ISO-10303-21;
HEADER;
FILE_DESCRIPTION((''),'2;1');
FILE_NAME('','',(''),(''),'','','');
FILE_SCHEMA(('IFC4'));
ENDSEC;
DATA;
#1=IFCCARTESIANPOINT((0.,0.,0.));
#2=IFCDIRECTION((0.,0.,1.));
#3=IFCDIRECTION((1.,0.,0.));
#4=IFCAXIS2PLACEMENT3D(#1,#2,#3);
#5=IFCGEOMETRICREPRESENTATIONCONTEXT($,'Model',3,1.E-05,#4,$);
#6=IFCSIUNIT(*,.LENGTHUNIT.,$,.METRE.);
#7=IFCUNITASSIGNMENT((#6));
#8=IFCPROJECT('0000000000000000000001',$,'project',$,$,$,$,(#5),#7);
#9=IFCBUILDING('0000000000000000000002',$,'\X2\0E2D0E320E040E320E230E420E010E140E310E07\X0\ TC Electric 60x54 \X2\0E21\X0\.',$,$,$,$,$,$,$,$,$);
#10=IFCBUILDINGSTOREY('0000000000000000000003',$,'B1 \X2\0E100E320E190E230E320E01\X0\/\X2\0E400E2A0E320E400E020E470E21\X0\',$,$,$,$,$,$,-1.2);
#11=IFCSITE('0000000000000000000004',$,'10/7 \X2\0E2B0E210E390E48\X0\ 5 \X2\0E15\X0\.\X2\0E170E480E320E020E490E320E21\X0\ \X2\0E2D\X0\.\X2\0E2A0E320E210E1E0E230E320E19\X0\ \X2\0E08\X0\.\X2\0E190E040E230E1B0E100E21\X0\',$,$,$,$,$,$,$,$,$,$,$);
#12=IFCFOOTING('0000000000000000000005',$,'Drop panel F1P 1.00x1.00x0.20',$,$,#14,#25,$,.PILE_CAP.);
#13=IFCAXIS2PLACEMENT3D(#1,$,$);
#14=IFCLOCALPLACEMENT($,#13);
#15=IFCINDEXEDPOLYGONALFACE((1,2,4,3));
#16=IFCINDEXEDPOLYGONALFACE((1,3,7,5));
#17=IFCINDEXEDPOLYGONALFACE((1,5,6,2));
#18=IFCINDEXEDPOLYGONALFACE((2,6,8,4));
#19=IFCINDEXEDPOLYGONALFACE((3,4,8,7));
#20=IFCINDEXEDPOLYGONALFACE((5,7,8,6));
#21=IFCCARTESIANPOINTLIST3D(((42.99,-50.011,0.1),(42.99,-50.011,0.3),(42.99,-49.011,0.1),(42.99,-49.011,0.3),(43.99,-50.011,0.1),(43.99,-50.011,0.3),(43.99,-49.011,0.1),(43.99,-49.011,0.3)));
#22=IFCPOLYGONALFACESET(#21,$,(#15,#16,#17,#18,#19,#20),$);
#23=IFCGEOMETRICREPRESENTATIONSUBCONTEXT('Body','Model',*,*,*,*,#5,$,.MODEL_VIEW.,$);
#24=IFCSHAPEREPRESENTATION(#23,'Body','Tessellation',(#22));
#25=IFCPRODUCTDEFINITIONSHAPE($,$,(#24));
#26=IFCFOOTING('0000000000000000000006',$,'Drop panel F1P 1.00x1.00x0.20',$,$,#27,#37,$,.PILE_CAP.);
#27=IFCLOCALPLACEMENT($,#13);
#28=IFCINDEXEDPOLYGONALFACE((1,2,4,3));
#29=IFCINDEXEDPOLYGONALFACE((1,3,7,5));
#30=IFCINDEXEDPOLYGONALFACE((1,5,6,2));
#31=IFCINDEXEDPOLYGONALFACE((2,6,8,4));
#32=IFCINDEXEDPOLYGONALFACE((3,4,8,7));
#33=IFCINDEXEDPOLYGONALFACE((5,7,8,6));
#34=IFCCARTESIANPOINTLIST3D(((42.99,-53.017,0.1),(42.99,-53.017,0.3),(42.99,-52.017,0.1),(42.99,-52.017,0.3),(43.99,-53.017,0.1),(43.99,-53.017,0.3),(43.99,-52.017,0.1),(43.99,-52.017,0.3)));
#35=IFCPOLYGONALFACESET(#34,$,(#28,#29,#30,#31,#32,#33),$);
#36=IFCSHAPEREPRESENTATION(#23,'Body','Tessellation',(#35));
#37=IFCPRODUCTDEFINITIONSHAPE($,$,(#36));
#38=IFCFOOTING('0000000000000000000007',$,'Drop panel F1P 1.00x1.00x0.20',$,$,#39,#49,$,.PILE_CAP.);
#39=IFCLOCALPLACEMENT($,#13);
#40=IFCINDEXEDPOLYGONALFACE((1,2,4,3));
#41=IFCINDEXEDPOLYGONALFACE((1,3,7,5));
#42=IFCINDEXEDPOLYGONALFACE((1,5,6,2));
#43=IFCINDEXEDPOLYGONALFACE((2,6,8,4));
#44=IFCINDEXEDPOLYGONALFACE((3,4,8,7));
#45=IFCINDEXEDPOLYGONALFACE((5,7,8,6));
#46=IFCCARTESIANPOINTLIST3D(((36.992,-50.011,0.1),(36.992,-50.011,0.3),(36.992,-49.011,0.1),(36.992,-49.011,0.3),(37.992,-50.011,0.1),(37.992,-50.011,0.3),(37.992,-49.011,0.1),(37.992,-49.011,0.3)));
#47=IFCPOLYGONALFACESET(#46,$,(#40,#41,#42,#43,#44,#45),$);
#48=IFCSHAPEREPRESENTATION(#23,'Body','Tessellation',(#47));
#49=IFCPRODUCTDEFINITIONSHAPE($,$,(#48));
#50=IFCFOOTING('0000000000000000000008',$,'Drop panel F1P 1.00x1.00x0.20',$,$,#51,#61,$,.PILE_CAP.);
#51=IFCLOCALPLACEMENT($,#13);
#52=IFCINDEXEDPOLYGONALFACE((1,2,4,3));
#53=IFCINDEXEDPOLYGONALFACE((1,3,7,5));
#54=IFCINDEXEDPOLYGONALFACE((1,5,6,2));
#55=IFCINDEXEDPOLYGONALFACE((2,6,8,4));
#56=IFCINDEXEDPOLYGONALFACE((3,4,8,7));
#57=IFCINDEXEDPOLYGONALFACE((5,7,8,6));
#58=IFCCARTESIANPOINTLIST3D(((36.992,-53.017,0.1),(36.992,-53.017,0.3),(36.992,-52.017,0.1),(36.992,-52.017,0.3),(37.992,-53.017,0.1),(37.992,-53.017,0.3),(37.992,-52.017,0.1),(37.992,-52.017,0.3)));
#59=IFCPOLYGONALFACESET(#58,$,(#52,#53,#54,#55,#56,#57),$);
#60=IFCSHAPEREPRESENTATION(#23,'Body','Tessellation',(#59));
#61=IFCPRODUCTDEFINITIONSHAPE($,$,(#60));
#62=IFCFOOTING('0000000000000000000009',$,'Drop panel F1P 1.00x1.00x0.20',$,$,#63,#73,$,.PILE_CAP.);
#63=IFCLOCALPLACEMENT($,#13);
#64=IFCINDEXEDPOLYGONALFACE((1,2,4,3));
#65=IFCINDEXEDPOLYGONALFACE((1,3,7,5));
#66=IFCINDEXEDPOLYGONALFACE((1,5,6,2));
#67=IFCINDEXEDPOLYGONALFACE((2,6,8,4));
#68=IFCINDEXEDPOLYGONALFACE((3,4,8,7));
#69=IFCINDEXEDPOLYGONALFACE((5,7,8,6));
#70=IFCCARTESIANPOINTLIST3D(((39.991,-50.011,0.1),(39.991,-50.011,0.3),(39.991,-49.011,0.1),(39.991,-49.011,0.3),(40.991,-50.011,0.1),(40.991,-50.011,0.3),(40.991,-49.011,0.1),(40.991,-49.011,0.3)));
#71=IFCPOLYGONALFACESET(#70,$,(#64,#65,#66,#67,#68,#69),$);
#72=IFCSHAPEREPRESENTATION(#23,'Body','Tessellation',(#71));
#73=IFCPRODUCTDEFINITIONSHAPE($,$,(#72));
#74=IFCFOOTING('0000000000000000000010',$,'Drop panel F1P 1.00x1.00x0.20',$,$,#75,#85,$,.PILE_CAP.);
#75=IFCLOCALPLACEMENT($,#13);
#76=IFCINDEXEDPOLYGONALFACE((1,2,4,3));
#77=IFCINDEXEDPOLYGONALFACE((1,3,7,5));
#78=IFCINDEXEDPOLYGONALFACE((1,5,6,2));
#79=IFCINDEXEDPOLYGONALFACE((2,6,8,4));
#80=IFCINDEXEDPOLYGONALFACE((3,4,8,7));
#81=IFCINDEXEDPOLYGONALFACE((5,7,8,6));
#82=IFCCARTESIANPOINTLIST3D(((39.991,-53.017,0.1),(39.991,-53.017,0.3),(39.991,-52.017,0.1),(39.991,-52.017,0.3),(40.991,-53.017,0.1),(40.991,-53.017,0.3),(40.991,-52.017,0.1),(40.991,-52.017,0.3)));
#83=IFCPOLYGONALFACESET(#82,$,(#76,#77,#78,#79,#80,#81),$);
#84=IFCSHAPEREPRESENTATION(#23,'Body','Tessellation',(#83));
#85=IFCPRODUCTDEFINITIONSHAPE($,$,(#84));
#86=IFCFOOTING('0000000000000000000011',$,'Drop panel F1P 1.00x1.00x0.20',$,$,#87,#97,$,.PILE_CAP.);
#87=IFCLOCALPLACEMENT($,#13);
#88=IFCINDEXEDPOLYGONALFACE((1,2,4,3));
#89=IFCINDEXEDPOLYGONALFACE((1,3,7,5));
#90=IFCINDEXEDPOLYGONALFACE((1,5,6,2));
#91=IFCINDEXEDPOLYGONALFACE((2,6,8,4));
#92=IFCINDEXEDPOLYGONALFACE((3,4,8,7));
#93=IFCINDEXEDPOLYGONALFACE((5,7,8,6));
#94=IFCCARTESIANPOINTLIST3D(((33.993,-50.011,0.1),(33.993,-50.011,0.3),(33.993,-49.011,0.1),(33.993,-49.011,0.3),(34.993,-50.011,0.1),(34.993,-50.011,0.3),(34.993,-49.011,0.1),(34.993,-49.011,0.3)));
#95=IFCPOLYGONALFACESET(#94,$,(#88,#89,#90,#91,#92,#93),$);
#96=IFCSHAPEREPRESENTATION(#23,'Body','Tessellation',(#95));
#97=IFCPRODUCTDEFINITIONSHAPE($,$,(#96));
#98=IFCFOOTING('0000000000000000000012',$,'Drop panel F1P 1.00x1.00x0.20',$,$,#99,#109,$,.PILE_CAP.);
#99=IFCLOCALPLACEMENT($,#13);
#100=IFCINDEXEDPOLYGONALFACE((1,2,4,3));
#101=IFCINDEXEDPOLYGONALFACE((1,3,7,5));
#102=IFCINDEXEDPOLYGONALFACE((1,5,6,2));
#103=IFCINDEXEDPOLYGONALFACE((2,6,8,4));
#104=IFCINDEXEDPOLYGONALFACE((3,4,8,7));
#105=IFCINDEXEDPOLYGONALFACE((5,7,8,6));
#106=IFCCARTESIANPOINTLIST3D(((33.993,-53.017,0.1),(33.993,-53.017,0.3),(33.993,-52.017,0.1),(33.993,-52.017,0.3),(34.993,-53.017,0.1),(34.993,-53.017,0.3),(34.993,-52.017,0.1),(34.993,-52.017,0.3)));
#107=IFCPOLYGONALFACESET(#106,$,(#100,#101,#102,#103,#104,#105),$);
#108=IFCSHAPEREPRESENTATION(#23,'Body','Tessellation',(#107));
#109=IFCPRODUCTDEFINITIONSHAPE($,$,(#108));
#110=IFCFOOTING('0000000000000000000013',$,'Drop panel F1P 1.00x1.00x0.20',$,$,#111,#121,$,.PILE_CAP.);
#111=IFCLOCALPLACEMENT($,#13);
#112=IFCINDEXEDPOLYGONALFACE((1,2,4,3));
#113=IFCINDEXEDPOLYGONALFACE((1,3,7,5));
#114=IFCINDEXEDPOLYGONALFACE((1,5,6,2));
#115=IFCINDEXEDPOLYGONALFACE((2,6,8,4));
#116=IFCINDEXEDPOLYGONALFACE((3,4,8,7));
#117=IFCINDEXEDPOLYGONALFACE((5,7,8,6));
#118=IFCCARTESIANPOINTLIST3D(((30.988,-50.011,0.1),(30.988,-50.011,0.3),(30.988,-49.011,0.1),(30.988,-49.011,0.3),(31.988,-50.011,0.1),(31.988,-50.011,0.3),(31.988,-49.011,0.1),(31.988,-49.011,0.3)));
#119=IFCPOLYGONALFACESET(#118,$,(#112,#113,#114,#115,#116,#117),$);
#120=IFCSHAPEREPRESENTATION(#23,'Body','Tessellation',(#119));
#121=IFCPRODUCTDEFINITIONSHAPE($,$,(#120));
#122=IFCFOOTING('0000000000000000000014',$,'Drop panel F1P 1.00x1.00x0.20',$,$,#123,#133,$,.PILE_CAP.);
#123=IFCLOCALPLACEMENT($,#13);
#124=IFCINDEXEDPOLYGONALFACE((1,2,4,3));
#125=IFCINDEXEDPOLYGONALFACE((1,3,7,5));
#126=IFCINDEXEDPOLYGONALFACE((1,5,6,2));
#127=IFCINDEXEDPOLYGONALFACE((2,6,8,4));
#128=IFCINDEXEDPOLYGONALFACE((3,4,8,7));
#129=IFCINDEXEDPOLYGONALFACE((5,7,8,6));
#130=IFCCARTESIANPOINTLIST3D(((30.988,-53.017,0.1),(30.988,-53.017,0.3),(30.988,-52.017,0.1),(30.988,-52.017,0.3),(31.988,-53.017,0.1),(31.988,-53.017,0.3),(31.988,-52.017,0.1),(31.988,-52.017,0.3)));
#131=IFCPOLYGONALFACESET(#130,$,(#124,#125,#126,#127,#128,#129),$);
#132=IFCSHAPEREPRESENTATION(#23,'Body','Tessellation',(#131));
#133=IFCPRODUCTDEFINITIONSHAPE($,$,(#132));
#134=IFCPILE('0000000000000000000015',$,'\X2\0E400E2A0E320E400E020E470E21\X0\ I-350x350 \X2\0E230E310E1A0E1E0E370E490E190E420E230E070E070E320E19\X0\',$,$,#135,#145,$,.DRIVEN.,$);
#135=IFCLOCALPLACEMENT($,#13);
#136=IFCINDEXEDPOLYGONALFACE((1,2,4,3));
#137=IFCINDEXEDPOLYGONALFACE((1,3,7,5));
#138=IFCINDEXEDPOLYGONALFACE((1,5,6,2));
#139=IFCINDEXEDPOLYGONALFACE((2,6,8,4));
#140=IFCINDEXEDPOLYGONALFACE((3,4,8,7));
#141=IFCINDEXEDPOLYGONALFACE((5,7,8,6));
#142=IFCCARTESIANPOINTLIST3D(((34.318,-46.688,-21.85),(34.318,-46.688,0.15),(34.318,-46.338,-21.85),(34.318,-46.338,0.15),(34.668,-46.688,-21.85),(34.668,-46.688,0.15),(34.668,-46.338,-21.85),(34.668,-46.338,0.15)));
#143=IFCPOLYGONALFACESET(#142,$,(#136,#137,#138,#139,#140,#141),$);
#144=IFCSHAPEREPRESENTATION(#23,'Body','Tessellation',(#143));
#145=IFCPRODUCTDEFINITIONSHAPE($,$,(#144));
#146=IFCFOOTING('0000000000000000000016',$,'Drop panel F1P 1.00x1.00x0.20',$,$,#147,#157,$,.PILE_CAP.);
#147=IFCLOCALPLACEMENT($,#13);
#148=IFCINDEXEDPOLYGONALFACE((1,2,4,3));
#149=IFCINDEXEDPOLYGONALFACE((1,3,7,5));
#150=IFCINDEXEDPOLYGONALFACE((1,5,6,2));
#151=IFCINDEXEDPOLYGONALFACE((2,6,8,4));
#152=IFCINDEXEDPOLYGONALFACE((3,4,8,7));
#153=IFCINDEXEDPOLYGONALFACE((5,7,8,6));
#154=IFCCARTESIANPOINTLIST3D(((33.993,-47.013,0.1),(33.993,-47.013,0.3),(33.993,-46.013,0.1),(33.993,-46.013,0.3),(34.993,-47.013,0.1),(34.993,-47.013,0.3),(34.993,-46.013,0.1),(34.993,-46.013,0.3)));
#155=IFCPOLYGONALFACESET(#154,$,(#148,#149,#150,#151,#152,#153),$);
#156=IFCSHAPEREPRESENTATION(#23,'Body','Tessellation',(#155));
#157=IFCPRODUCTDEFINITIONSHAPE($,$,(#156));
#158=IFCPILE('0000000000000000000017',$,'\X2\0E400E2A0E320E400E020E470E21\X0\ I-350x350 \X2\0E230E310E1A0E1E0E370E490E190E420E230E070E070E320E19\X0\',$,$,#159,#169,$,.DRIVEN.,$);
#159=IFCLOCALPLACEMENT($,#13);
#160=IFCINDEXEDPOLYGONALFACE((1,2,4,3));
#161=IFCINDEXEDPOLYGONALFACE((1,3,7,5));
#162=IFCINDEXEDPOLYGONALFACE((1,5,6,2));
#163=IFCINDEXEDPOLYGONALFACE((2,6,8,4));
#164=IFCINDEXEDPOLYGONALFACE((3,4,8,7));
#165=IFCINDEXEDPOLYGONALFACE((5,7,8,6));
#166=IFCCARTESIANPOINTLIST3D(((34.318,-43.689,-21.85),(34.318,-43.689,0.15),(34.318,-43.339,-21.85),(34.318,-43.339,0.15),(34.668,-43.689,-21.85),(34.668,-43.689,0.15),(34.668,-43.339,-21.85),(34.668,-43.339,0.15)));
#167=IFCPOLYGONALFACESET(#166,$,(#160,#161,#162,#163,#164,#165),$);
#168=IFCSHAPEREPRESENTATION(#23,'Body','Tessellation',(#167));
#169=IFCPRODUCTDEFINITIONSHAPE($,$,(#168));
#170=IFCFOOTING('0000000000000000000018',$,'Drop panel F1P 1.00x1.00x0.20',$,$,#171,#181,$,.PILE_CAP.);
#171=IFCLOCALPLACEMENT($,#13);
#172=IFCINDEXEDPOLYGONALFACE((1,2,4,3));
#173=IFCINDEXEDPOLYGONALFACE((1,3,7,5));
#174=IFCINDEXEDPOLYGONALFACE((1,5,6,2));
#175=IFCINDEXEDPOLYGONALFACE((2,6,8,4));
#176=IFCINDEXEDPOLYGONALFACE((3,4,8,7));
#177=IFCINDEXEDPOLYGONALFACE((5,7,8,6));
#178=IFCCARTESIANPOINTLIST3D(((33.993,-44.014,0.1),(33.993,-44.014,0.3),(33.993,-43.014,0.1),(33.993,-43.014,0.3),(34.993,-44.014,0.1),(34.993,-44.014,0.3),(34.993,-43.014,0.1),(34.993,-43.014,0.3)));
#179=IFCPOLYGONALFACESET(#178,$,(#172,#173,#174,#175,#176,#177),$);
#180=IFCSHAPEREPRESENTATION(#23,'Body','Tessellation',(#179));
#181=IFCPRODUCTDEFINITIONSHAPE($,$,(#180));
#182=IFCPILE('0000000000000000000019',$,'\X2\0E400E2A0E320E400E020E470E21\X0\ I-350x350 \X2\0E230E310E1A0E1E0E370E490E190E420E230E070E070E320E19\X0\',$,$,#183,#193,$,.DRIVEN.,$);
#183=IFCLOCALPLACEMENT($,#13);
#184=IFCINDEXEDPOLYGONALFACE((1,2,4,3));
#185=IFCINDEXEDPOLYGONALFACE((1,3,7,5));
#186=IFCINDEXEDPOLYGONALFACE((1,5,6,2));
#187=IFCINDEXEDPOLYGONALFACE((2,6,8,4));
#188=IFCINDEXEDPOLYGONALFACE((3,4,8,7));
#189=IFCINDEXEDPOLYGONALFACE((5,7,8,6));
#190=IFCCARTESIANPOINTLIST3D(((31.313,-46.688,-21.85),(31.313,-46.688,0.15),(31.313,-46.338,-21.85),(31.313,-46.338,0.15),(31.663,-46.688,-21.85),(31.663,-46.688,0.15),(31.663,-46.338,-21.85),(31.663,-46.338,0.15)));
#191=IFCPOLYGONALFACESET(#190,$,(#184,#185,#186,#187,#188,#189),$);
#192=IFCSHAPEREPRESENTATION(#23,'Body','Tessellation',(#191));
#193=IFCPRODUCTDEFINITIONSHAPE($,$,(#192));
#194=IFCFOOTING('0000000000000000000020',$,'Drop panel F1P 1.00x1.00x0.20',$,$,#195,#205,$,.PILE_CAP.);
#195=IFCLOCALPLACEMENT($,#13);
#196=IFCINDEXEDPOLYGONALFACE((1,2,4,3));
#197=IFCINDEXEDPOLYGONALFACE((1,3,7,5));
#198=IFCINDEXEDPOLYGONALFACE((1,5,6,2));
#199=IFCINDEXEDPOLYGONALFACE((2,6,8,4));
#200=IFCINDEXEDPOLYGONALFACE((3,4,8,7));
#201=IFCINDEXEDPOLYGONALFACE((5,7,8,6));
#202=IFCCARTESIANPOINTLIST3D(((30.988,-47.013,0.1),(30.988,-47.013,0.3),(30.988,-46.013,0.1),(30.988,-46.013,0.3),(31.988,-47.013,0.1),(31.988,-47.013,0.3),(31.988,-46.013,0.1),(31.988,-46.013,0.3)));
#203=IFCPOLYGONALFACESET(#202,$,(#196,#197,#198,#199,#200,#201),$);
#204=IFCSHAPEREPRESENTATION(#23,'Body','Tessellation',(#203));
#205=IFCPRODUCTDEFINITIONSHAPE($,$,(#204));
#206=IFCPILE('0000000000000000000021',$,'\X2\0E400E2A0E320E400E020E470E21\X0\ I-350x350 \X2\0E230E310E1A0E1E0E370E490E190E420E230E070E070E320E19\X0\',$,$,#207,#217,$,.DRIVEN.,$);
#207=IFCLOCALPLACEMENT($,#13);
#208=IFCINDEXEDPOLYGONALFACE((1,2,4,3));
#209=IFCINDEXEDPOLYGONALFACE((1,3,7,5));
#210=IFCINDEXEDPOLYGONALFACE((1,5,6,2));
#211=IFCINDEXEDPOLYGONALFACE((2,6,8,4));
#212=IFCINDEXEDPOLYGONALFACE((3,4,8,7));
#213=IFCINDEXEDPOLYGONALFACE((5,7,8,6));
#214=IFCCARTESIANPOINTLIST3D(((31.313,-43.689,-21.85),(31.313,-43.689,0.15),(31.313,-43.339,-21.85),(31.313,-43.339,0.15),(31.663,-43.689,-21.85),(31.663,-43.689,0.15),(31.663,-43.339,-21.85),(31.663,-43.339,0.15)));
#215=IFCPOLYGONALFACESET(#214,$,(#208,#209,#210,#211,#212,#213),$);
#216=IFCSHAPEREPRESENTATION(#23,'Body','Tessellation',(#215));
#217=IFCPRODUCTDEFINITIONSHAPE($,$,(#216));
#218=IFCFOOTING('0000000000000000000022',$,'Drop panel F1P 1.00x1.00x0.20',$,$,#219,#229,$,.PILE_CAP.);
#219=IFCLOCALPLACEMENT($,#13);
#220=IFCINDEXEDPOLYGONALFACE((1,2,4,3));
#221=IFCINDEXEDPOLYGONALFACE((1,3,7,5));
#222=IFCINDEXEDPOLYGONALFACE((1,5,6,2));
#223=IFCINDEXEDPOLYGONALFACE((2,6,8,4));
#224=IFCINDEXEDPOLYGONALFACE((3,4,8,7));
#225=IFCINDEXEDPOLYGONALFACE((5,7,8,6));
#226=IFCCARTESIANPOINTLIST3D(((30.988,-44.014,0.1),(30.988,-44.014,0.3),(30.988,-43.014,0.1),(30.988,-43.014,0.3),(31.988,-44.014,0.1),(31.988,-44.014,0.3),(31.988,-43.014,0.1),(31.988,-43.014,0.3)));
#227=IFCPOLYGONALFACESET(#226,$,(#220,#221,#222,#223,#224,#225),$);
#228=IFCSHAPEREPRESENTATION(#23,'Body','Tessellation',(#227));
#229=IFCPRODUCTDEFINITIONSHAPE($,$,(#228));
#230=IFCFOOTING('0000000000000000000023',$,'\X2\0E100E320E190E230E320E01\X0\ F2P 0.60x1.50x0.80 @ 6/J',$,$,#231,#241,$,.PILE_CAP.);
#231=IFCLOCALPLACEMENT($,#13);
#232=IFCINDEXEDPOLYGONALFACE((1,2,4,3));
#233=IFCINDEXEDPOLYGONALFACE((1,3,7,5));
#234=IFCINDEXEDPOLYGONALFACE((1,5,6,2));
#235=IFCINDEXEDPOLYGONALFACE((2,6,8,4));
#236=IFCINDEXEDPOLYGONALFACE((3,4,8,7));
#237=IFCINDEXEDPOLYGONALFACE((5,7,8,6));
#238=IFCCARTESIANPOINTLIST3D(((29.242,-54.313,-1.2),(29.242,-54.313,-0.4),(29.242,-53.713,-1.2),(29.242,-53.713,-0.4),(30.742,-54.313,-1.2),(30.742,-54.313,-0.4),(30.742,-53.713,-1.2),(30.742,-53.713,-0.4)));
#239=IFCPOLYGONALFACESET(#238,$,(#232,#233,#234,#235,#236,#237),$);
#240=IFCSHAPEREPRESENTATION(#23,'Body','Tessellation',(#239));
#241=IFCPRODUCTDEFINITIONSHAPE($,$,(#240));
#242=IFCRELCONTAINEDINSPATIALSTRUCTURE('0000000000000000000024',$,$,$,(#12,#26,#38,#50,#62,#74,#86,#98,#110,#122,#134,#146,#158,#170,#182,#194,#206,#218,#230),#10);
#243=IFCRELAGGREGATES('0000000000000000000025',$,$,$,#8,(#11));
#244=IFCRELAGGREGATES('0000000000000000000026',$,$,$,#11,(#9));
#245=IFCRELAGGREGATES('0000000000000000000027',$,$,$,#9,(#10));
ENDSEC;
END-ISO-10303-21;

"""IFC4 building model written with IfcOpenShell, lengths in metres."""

from ifc_helpers import new_model, si_unit, frame, origin, origin_with_axes, origin_2d, place, context, subcontext, project, spatial, rectangle, extrude, element, save


model = new_model("IFC4")

# Units and contexts
model_context = context("Model", 3, precision=1e-05, world=origin_with_axes())
body_context = subcontext(model_context, "Body", "Model", "MODEL_VIEW")
ifc_project = project(units=[si_unit("LENGTHUNIT", "METRE")], contexts=[model_context])

# Site, building, storey
site = spatial("IfcSite", under=ifc_project, Name="10/7 หมู่ 5 ต.ท่าข้าม อ.สามพราน จ.นครปฐม")
building = spatial("IfcBuilding", under=site, Name="อาคารโกดัง TC Electric 60x54 ม.")
storey = spatial("IfcBuildingStorey", under=building, Name="B1 ฐานราก/เสาเข็ม", Elevation=-1.2)

# Footings
for number, where, z_axis, x_axis, name in (
    (1, (43.49, -49.511, 0.1), (0.0, 0.0, 1.0), (1.0, 0.0, 0.0), "Drop panel F1P 1.00x1.00x0.20"),
    (2, (43.49, -52.517, 0.1), (0.0, 0.0, 1.0), (1.0, 0.0, 0.0), "Drop panel F1P 1.00x1.00x0.20"),
    (3, (37.492, -49.511, 0.1), (0.0, 0.0, 1.0), (1.0, 0.0, 0.0), "Drop panel F1P 1.00x1.00x0.20"),
    (4, (37.492, -52.517, 0.1), (0.0, 0.0, 1.0), (1.0, 0.0, 0.0), "Drop panel F1P 1.00x1.00x0.20"),
    (5, (40.491, -49.511, 0.1), (0.0, 0.0, 1.0), (1.0, 0.0, 0.0), "Drop panel F1P 1.00x1.00x0.20"),
    (6, (40.491, -52.517, 0.1), (0.0, 0.0, 1.0), (1.0, 0.0, 0.0), "Drop panel F1P 1.00x1.00x0.20"),
    (7, (34.493, -49.511, 0.1), (0.0, 0.0, 1.0), (1.0, 0.0, 0.0), "Drop panel F1P 1.00x1.00x0.20"),
    (8, (34.493, -52.517, 0.1), (0.0, 0.0, 1.0), (1.0, 0.0, 0.0), "Drop panel F1P 1.00x1.00x0.20"),
    (9, (31.488, -49.511, 0.1), (0.0, 0.0, 1.0), (1.0, 0.0, 0.0), "Drop panel F1P 1.00x1.00x0.20"),
    (10, (31.488, -52.517, 0.1), (0.0, 0.0, 1.0), (1.0, 0.0, 0.0), "Drop panel F1P 1.00x1.00x0.20"),
):
    element("IfcFooting", number, at=place(None, frame(where, z_axis=z_axis, x_axis=x_axis)), inside=storey, Name=name, PredefinedType="PILE_CAP", context=body_context, shape_type="SweptSolid", body=[
        extrude(rectangle(XDim=1.0, YDim=1.0, at=origin_2d()), origin(), (0.0, 0.0, 1.0), 0.2),
    ])

# Pile
pile_1_placement = place(None, frame((34.493, -46.513, -21.85), z_axis=(0.0, 0.0, 1.0), x_axis=(1.0, 0.0, 0.0)))
element("IfcPile", 11, at=pile_1_placement, inside=storey, Name="เสาเข็ม I-350x350 รับพื้นโรงงาน", PredefinedType="DRIVEN", context=body_context, shape_type="SweptSolid", body=[
    extrude(rectangle(XDim=0.35, YDim=0.35, at=origin_2d()), origin(), (0.0, 0.0, 1.0), 22.0),
])

# Footing
footing_1_placement = place(None, frame((34.493, -46.513, 0.1), z_axis=(0.0, 0.0, 1.0), x_axis=(1.0, 0.0, 0.0)))
element("IfcFooting", 12, at=footing_1_placement, inside=storey, Name="Drop panel F1P 1.00x1.00x0.20", PredefinedType="PILE_CAP", context=body_context, shape_type="SweptSolid", body=[
    extrude(rectangle(XDim=1.0, YDim=1.0, at=origin_2d()), origin(), (0.0, 0.0, 1.0), 0.2),
])

# Pile
pile_2_placement = place(None, frame((34.493, -43.514, -21.85), z_axis=(0.0, 0.0, 1.0), x_axis=(1.0, 0.0, 0.0)))
element("IfcPile", 13, at=pile_2_placement, inside=storey, Name="เสาเข็ม I-350x350 รับพื้นโรงงาน", PredefinedType="DRIVEN", context=body_context, shape_type="SweptSolid", body=[
    extrude(rectangle(XDim=0.35, YDim=0.35, at=origin_2d()), origin(), (0.0, 0.0, 1.0), 22.0),
])

# Footing
footing_2_placement = place(None, frame((34.493, -43.514, 0.1), z_axis=(0.0, 0.0, 1.0), x_axis=(1.0, 0.0, 0.0)))
element("IfcFooting", 14, at=footing_2_placement, inside=storey, Name="Drop panel F1P 1.00x1.00x0.20", PredefinedType="PILE_CAP", context=body_context, shape_type="SweptSolid", body=[
    extrude(rectangle(XDim=1.0, YDim=1.0, at=origin_2d()), origin(), (0.0, 0.0, 1.0), 0.2),
])

# Pile
pile_3_placement = place(None, frame((31.488, -46.513, -21.85), z_axis=(0.0, 0.0, 1.0), x_axis=(1.0, 0.0, 0.0)))
element("IfcPile", 15, at=pile_3_placement, inside=storey, Name="เสาเข็ม I-350x350 รับพื้นโรงงาน", PredefinedType="DRIVEN", context=body_context, shape_type="SweptSolid", body=[
    extrude(rectangle(XDim=0.35, YDim=0.35, at=origin_2d()), origin(), (0.0, 0.0, 1.0), 22.0),
])

# Footing
footing_3_placement = place(None, frame((31.488, -46.513, 0.1), z_axis=(0.0, 0.0, 1.0), x_axis=(1.0, 0.0, 0.0)))
element("IfcFooting", 16, at=footing_3_placement, inside=storey, Name="Drop panel F1P 1.00x1.00x0.20", PredefinedType="PILE_CAP", context=body_context, shape_type="SweptSolid", body=[
    extrude(rectangle(XDim=1.0, YDim=1.0, at=origin_2d()), origin(), (0.0, 0.0, 1.0), 0.2),
])

# Pile
pile_4_placement = place(None, frame((31.488, -43.514, -21.85), z_axis=(0.0, 0.0, 1.0), x_axis=(1.0, 0.0, 0.0)))
element("IfcPile", 17, at=pile_4_placement, inside=storey, Name="เสาเข็ม I-350x350 รับพื้นโรงงาน", PredefinedType="DRIVEN", context=body_context, shape_type="SweptSolid", body=[
    extrude(rectangle(XDim=0.35, YDim=0.35, at=origin_2d()), origin(), (0.0, 0.0, 1.0), 22.0),
])

# Footings
footing_4_placement = place(None, frame((31.488, -43.514, 0.1), z_axis=(0.0, 0.0, 1.0), x_axis=(1.0, 0.0, 0.0)))
element("IfcFooting", 18, at=footing_4_placement, inside=storey, Name="Drop panel F1P 1.00x1.00x0.20", PredefinedType="PILE_CAP", context=body_context, shape_type="SweptSolid", body=[
    extrude(rectangle(XDim=1.0, YDim=1.0, at=origin_2d()), origin(), (0.0, 0.0, 1.0), 0.2),
])
for number, where, z_axis, x_axis, name in (
    (19, (29.992, -54.013, -1.2), (0.0, 0.0, 1.0), (1.0, 0.0, 0.0), "ฐานราก F2P 0.60x1.50x0.80 @ 6/J"),
):
    element("IfcFooting", number, at=place(None, frame(where, z_axis=z_axis, x_axis=x_axis)), inside=storey, Name=name, PredefinedType="PILE_CAP", context=body_context, shape_type="SweptSolid", body=[
        extrude(rectangle(XDim=1.5, YDim=0.6, at=origin_2d()), origin(), (0.0, 0.0, 1.0), 0.8),
    ])

save(model, "model.ifc")
